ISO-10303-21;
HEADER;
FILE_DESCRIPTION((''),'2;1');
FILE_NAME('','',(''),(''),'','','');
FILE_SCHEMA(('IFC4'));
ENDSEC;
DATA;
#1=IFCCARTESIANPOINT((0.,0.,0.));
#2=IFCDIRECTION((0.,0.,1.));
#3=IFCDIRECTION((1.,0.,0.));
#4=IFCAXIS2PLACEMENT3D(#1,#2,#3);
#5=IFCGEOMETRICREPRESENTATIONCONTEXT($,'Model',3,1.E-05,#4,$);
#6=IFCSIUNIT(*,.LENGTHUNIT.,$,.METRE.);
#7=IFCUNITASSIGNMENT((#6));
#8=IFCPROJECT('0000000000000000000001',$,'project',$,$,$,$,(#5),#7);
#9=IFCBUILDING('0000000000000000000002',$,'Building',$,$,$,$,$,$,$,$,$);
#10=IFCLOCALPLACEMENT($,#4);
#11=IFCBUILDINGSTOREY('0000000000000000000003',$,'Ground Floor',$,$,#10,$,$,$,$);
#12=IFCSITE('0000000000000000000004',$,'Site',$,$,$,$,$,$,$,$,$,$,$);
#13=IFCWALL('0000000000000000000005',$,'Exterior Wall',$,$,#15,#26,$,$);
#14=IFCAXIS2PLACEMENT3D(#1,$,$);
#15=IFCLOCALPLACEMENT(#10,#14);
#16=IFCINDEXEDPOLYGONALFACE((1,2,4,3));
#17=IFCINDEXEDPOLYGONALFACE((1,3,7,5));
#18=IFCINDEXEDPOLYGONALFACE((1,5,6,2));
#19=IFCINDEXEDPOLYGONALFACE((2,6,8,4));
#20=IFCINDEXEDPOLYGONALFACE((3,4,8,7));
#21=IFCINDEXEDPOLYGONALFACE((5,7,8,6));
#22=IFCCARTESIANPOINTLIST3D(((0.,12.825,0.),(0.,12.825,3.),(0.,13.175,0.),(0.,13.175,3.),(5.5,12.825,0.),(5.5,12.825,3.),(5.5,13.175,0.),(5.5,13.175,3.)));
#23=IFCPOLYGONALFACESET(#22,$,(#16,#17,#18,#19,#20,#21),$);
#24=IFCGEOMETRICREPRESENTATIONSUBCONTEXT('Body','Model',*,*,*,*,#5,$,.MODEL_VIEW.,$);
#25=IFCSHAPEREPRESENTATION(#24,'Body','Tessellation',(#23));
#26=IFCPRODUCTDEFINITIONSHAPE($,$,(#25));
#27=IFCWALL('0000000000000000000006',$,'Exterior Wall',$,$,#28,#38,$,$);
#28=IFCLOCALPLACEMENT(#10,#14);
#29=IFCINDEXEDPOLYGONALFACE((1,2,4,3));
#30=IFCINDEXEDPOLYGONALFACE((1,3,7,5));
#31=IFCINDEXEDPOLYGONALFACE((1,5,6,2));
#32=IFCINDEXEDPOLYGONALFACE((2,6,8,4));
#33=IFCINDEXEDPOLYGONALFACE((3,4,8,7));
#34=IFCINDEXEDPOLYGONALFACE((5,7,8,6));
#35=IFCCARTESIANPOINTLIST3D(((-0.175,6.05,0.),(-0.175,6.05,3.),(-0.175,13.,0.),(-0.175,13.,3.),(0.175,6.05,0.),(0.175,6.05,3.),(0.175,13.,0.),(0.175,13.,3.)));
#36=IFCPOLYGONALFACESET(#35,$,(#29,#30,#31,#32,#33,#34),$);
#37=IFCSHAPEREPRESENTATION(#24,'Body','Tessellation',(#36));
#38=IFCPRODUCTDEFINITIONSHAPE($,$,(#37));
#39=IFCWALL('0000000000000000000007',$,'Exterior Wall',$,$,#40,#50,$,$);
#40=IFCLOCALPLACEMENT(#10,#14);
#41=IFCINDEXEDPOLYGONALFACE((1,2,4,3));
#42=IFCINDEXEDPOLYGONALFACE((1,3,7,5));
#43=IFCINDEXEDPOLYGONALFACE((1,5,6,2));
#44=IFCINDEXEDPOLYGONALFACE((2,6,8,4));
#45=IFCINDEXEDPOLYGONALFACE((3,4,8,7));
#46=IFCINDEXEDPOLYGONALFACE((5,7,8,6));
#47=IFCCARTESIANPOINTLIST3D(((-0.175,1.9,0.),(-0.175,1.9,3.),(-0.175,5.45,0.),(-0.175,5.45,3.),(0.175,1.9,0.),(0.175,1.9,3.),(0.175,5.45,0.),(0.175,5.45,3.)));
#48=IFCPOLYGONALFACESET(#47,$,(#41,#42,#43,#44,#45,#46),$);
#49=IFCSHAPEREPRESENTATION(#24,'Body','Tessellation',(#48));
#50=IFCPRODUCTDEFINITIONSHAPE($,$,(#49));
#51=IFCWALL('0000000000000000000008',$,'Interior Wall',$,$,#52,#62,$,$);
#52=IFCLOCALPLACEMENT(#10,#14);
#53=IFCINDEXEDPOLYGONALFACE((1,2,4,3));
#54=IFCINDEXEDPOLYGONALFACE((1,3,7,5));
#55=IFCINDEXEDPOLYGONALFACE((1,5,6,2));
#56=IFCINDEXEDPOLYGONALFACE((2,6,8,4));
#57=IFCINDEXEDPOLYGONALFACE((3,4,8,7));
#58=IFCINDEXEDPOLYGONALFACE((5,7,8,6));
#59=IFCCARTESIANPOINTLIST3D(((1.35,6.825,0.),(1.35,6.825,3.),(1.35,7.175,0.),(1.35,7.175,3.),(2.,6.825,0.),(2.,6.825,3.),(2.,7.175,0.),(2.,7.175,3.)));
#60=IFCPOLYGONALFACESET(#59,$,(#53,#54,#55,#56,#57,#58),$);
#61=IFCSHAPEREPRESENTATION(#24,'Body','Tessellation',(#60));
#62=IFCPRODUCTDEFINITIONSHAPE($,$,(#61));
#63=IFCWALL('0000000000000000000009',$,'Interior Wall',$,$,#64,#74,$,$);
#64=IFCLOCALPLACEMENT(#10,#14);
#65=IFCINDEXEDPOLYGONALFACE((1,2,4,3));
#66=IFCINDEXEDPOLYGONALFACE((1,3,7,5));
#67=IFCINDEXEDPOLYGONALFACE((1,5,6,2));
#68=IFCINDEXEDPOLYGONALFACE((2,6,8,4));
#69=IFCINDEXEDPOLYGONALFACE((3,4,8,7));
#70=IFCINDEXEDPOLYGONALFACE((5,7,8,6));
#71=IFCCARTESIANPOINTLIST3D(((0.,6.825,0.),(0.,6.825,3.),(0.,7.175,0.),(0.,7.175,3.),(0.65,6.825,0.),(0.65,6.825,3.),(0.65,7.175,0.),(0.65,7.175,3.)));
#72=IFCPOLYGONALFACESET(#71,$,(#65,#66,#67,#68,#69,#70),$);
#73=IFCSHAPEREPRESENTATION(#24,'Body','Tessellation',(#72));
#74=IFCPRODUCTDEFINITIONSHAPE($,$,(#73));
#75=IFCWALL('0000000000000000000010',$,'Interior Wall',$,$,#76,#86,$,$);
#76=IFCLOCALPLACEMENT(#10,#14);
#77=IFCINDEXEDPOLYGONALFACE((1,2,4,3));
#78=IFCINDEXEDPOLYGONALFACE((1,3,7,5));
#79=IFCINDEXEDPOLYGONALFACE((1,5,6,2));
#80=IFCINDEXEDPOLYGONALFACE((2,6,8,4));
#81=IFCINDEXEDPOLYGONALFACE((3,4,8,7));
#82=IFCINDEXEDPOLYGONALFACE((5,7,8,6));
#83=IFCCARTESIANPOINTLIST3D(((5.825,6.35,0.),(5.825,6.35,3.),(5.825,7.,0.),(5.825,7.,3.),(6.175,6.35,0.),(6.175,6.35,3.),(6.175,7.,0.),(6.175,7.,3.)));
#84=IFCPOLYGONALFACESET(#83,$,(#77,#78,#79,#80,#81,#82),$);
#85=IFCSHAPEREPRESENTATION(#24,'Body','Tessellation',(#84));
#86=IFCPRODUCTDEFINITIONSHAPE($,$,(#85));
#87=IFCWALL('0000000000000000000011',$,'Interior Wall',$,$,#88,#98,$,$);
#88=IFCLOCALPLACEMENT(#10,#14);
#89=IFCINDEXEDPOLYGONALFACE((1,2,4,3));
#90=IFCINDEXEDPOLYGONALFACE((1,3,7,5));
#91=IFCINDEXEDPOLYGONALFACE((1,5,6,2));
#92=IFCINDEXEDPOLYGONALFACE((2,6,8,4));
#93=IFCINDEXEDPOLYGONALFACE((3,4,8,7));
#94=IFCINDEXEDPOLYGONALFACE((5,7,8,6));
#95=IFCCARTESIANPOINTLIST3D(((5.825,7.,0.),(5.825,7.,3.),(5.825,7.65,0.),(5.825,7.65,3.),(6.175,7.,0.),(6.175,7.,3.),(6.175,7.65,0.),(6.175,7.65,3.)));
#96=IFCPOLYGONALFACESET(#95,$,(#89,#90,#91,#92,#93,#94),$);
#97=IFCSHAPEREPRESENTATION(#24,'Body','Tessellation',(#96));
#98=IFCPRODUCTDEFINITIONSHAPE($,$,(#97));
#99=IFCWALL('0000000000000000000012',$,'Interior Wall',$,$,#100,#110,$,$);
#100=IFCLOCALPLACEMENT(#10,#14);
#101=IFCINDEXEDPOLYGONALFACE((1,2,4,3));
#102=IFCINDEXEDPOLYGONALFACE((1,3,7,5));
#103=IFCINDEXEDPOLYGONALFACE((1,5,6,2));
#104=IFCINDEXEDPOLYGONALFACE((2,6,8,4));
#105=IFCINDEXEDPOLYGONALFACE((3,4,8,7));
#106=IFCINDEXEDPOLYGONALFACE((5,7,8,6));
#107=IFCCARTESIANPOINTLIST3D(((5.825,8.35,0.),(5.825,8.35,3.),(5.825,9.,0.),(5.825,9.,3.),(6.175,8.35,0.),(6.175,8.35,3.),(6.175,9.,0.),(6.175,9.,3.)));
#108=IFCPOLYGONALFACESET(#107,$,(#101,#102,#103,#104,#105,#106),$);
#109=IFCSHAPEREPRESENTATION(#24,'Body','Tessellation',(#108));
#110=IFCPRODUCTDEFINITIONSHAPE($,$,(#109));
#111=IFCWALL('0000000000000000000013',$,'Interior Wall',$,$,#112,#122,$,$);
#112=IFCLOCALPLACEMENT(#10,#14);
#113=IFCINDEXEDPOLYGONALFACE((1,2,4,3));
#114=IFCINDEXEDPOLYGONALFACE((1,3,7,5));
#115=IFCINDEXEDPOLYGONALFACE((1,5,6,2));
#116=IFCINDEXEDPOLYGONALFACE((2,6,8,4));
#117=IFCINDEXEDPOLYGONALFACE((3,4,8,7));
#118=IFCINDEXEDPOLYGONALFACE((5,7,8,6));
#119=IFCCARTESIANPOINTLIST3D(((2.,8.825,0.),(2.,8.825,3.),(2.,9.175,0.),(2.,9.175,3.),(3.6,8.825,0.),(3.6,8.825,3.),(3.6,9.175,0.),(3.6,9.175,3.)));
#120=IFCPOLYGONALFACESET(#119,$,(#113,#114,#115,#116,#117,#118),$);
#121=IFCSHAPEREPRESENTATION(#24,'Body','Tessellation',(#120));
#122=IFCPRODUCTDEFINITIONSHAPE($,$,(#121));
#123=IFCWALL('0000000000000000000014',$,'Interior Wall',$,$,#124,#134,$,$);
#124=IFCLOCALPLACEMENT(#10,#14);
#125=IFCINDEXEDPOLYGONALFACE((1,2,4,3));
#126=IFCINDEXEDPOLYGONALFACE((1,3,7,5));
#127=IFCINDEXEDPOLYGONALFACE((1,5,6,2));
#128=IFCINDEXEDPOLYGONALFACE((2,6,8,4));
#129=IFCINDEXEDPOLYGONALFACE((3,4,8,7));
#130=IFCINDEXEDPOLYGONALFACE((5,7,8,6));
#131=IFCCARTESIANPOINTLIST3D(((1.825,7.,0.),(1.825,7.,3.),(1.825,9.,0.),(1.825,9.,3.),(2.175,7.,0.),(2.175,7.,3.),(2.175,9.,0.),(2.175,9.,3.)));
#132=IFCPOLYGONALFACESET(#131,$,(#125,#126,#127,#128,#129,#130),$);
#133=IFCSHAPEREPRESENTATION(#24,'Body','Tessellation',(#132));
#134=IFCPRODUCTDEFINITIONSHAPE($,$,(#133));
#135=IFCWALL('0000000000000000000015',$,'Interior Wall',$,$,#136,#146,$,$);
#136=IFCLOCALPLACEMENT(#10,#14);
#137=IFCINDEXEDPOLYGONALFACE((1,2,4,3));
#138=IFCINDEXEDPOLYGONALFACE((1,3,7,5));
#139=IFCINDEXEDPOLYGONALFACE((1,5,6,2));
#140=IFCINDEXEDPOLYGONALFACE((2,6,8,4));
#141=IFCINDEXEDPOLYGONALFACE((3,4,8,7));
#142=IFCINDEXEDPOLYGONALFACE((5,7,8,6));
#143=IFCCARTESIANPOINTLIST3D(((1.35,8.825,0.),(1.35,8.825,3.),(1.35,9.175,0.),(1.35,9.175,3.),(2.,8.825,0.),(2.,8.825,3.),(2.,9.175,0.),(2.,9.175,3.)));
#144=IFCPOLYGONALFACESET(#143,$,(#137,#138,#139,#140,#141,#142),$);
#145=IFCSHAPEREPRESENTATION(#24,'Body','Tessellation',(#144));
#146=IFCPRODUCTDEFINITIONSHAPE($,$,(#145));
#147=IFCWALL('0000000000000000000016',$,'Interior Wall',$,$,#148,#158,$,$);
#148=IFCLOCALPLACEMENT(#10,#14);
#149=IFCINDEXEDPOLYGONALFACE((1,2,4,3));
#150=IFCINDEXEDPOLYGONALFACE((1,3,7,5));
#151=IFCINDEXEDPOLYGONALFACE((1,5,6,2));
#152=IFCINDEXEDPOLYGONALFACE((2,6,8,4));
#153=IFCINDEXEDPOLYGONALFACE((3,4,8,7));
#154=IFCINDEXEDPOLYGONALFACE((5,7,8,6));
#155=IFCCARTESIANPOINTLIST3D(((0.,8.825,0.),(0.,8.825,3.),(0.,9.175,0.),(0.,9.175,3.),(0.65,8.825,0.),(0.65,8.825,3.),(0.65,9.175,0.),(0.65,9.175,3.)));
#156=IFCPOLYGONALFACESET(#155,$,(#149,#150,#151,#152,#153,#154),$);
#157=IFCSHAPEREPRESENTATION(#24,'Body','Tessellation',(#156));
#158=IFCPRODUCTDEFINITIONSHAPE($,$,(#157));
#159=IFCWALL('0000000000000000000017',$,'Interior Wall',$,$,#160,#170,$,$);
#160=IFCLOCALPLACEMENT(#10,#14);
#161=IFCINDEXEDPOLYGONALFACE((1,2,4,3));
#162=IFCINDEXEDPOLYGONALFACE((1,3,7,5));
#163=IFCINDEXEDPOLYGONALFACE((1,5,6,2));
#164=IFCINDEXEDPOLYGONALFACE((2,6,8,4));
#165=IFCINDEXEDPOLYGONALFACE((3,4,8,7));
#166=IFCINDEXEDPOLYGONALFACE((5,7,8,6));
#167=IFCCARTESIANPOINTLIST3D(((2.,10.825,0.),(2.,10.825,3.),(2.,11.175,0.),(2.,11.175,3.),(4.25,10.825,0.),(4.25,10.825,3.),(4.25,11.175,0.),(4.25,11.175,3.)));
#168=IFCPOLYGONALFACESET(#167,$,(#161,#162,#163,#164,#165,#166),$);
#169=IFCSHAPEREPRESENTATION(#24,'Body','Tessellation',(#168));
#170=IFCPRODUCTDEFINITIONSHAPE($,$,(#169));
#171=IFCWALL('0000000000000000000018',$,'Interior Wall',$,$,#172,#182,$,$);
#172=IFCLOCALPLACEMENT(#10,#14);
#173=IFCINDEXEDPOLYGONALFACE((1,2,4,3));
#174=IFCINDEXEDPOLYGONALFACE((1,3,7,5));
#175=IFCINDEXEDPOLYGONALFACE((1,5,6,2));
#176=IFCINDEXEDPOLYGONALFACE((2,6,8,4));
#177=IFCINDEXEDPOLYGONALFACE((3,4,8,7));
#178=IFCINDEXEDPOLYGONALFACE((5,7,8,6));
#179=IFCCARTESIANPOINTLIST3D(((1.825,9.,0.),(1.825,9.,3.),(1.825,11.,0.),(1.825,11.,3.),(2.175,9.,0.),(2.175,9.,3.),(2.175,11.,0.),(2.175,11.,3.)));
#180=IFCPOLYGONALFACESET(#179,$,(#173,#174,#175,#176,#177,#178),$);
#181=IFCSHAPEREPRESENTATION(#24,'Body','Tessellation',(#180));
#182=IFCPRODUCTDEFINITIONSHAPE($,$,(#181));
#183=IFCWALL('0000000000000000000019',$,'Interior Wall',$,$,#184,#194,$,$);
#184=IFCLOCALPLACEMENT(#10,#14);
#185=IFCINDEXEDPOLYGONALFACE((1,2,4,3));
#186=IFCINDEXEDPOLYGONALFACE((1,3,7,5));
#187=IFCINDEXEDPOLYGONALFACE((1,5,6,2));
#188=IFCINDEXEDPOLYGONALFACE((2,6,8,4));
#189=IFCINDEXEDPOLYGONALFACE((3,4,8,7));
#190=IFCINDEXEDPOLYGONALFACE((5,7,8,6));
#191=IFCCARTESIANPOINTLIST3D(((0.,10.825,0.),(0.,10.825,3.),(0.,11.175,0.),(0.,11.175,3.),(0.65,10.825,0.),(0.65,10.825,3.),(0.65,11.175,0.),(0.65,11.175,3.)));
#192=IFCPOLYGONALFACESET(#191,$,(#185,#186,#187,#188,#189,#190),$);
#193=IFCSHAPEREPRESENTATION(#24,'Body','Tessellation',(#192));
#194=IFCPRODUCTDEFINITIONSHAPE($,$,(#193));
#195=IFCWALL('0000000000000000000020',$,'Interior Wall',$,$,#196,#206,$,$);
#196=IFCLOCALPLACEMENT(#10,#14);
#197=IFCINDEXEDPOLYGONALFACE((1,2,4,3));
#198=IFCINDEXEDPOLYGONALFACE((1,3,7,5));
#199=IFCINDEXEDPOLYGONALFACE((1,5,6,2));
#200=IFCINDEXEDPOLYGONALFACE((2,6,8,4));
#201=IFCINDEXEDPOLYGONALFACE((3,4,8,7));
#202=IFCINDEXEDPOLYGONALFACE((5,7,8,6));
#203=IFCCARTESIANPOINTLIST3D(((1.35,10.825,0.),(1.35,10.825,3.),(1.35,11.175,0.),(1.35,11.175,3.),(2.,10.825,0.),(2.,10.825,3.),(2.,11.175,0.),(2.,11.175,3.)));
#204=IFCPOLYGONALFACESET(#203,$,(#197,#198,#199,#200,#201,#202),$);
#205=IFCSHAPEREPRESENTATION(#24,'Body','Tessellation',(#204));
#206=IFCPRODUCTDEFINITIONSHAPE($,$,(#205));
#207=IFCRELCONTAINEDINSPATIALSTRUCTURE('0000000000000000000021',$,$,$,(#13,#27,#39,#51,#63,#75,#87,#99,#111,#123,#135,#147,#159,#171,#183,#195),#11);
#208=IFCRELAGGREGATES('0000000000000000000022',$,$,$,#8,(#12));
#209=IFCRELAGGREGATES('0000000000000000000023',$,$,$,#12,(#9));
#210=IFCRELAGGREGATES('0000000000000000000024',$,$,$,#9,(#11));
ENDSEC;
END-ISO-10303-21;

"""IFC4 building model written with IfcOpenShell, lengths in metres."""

from ifc_helpers import new_model, si_unit, frame, origin_with_axes, place, context, subcontext, project, spatial, indexed_curve, outline, extrude, element, save


model = new_model("IFC4")

# Units and contexts
model_context = context("Model", 3, precision=1e-05, world=origin_with_axes())
body_context = subcontext(model_context, "Body", "Model", "MODEL_VIEW")
ifc_project = project(units=[si_unit("LENGTHUNIT", "METRE")], contexts=[model_context])

# Site, building, storey
site = spatial("IfcSite", under=ifc_project, Name="Site")
building = spatial("IfcBuilding", under=site, Name="Building")
storey_placement = place(None, origin_with_axes())
storey = spatial("IfcBuildingStorey", under=building, at=storey_placement, Name="Ground Floor")

# Walls
wall_1_placement = place(storey_placement, frame((5.5, 13.0, 0.0), z_axis=(0.0, 0.0, 1.0), x_axis=(-1.0, 0.0, 0.0)))
element("IfcWall", 1, at=wall_1_placement, inside=storey, Name="Exterior Wall", context=body_context, shape_type="SweptSolid", body=[
    extrude(outline(indexed_curve([(0.0, 0.0), (0.0, 0.35), (5.5, 0.35), (5.5, 0.0), (0.0, 0.0)], self_intersect=False)), frame((0.0, -0.175, 0.0), z_axis=(0.0, 0.0, 1.0), x_axis=(1.0, 0.0, 0.0)), (0.0, 0.0, 1.0), 3.0),
])
wall_2_placement = place(storey_placement, frame((0.0, 13.0, 0.0), z_axis=(0.0, 0.0, 1.0), x_axis=(0.0, -1.0, 0.0)))
element("IfcWall", 2, at=wall_2_placement, inside=storey, Name="Exterior Wall", context=body_context, shape_type="SweptSolid", body=[
    extrude(outline(indexed_curve([(0.0, 0.0), (0.0, 0.35), (6.95, 0.35), (6.95, 0.0), (0.0, 0.0)], self_intersect=False)), frame((0.0, -0.175, 0.0), z_axis=(0.0, 0.0, 1.0), x_axis=(1.0, 0.0, 0.0)), (0.0, 0.0, 1.0), 3.0),
])
wall_3_placement = place(storey_placement, frame((0.0, 5.45, 0.0), z_axis=(0.0, 0.0, 1.0), x_axis=(0.0, -1.0, 0.0)))
element("IfcWall", 3, at=wall_3_placement, inside=storey, Name="Exterior Wall", context=body_context, shape_type="SweptSolid", body=[
    extrude(outline(indexed_curve([(0.0, 0.0), (0.0, 0.35), (3.55, 0.35), (3.55, 0.0), (0.0, 0.0)], self_intersect=False)), frame((0.0, -0.175, 0.0), z_axis=(0.0, 0.0, 1.0), x_axis=(1.0, 0.0, 0.0)), (0.0, 0.0, 1.0), 3.0),
])
for number, where, z_axis, x_axis, name in (
    (4, (2.0, 7.0, 0.0), (0.0, 0.0, 1.0), (-1.0, 0.0, 0.0), "Interior Wall"),
    (5, (0.65, 7.0, 0.0), (0.0, 0.0, 1.0), (-1.0, 0.0, 0.0), "Interior Wall"),
):
    element("IfcWall", number, at=place(storey_placement, frame(where, z_axis=z_axis, x_axis=x_axis)), inside=storey, Name=name, context=body_context, shape_type="SweptSolid", body=[
        extrude(outline(indexed_curve([(0.0, 0.0), (0.0, 0.35), (0.65, 0.35), (0.65, 0.0), (0.0, 0.0)], self_intersect=False)), frame((0.0, -0.175, 0.0), z_axis=(0.0, 0.0, 1.0), x_axis=(1.0, 0.0, 0.0)), (0.0, 0.0, 1.0), 3.0),
    ])
for number, where, z_axis, x_axis, name in (
    (6, (6.0, 6.35, 0.0), (0.0, 0.0, 1.0), (0.0, 1.0, 0.0), "Interior Wall"),
    (7, (6.0, 7.0, 0.0), (0.0, 0.0, 1.0), (0.0, 1.0, 0.0), "Interior Wall"),
    (8, (6.0, 8.35, 0.0), (0.0, 0.0, 1.0), (0.0, 1.0, 0.0), "Interior Wall"),
):
    element("IfcWall", number, at=place(storey_placement, frame(where, z_axis=z_axis, x_axis=x_axis)), inside=storey, Name=name, context=body_context, shape_type="SweptSolid", body=[
        extrude(outline(indexed_curve([(0.0, 0.0), (0.0, 0.35), (0.65, 0.35), (0.65, 0.0), (0.0, 0.0)], self_intersect=False)), frame((0.0, -0.175, 0.0), z_axis=(0.0, 0.0, 1.0), x_axis=(1.0, 0.0, 0.0)), (0.0, 0.0, 1.0), 3.0),
    ])
wall_4_placement = place(storey_placement, frame((3.6, 9.0, 0.0), z_axis=(0.0, 0.0, 1.0), x_axis=(-1.0, 0.0, 0.0)))
element("IfcWall", 9, at=wall_4_placement, inside=storey, Name="Interior Wall", context=body_context, shape_type="SweptSolid", body=[
    extrude(outline(indexed_curve([(0.0, 0.0), (0.0, 0.35), (1.6, 0.35), (1.6, 0.0), (0.0, 0.0)], self_intersect=False)), frame((0.0, -0.175, 0.0), z_axis=(0.0, 0.0, 1.0), x_axis=(1.0, 0.0, 0.0)), (0.0, 0.0, 1.0), 3.0),
])
wall_5_placement = place(storey_placement, frame((2.0, 9.0, 0.0), z_axis=(0.0, 0.0, 1.0), x_axis=(0.0, -1.0, 0.0)))
element("IfcWall", 10, at=wall_5_placement, inside=storey, Name="Interior Wall", context=body_context, shape_type="SweptSolid", body=[
    extrude(outline(indexed_curve([(0.0, 0.0), (0.0, 0.35), (2.0, 0.35), (2.0, 0.0), (0.0, 0.0)], self_intersect=False)), frame((0.0, -0.175, 0.0), z_axis=(0.0, 0.0, 1.0), x_axis=(1.0, 0.0, 0.0)), (0.0, 0.0, 1.0), 3.0),
])
for number, where, z_axis, x_axis, name in (
    (11, (2.0, 9.0, 0.0), (0.0, 0.0, 1.0), (-1.0, 0.0, 0.0), "Interior Wall"),
    (12, (0.65, 9.0, 0.0), (0.0, 0.0, 1.0), (-1.0, 0.0, 0.0), "Interior Wall"),
):
    element("IfcWall", number, at=place(storey_placement, frame(where, z_axis=z_axis, x_axis=x_axis)), inside=storey, Name=name, context=body_context, shape_type="SweptSolid", body=[
        extrude(outline(indexed_curve([(0.0, 0.0), (0.0, 0.35), (0.65, 0.35), (0.65, 0.0), (0.0, 0.0)], self_intersect=False)), frame((0.0, -0.175, 0.0), z_axis=(0.0, 0.0, 1.0), x_axis=(1.0, 0.0, 0.0)), (0.0, 0.0, 1.0), 3.0),
    ])
wall_6_placement = place(storey_placement, frame((4.25, 11.0, 0.0), z_axis=(0.0, 0.0, 1.0), x_axis=(-1.0, 0.0, 0.0)))
element("IfcWall", 13, at=wall_6_placement, inside=storey, Name="Interior Wall", context=body_context, shape_type="SweptSolid", body=[
    extrude(outline(indexed_curve([(0.0, 0.0), (0.0, 0.35), (2.25, 0.35), (2.25, 0.0), (0.0, 0.0)], self_intersect=False)), frame((0.0, -0.175, 0.0), z_axis=(0.0, 0.0, 1.0), x_axis=(1.0, 0.0, 0.0)), (0.0, 0.0, 1.0), 3.0),
])
wall_7_placement = place(storey_placement, frame((2.0, 11.0, 0.0), z_axis=(0.0, 0.0, 1.0), x_axis=(0.0, -1.0, 0.0)))
element("IfcWall", 14, at=wall_7_placement, inside=storey, Name="Interior Wall", context=body_context, shape_type="SweptSolid", body=[
    extrude(outline(indexed_curve([(0.0, 0.0), (0.0, 0.35), (2.0, 0.35), (2.0, 0.0), (0.0, 0.0)], self_intersect=False)), frame((0.0, -0.175, 0.0), z_axis=(0.0, 0.0, 1.0), x_axis=(1.0, 0.0, 0.0)), (0.0, 0.0, 1.0), 3.0),
])
wall_8_placement = place(storey_placement, frame((0.0, 11.0, 0.0), z_axis=(0.0, 0.0, 1.0), x_axis=(1.0, 0.0, 0.0)))
element("IfcWall", 15, at=wall_8_placement, inside=storey, Name="Interior Wall", context=body_context, shape_type="SweptSolid", body=[
    extrude(outline(indexed_curve([(0.0, 0.0), (0.0, 0.35), (0.65, 0.35), (0.65, 0.0), (0.0, 0.0)], self_intersect=False)), frame((0.0, -0.175, 0.0), z_axis=(0.0, 0.0, 1.0), x_axis=(1.0, 0.0, 0.0)), (0.0, 0.0, 1.0), 3.0),
])
wall_9_placement = place(storey_placement, frame((1.35, 11.0, 0.0), z_axis=(0.0, 0.0, 1.0), x_axis=(1.0, 0.0, 0.0)))
element("IfcWall", 16, at=wall_9_placement, inside=storey, Name="Interior Wall", context=body_context, shape_type="SweptSolid", body=[
    extrude(outline(indexed_curve([(0.0, 0.0), (0.0, 0.35), (0.65, 0.35), (0.65, 0.0), (0.0, 0.0)], self_intersect=False)), frame((0.0, -0.175, 0.0), z_axis=(0.0, 0.0, 1.0), x_axis=(1.0, 0.0, 0.0)), (0.0, 0.0, 1.0), 3.0),
])

save(model, "model.ifc")
